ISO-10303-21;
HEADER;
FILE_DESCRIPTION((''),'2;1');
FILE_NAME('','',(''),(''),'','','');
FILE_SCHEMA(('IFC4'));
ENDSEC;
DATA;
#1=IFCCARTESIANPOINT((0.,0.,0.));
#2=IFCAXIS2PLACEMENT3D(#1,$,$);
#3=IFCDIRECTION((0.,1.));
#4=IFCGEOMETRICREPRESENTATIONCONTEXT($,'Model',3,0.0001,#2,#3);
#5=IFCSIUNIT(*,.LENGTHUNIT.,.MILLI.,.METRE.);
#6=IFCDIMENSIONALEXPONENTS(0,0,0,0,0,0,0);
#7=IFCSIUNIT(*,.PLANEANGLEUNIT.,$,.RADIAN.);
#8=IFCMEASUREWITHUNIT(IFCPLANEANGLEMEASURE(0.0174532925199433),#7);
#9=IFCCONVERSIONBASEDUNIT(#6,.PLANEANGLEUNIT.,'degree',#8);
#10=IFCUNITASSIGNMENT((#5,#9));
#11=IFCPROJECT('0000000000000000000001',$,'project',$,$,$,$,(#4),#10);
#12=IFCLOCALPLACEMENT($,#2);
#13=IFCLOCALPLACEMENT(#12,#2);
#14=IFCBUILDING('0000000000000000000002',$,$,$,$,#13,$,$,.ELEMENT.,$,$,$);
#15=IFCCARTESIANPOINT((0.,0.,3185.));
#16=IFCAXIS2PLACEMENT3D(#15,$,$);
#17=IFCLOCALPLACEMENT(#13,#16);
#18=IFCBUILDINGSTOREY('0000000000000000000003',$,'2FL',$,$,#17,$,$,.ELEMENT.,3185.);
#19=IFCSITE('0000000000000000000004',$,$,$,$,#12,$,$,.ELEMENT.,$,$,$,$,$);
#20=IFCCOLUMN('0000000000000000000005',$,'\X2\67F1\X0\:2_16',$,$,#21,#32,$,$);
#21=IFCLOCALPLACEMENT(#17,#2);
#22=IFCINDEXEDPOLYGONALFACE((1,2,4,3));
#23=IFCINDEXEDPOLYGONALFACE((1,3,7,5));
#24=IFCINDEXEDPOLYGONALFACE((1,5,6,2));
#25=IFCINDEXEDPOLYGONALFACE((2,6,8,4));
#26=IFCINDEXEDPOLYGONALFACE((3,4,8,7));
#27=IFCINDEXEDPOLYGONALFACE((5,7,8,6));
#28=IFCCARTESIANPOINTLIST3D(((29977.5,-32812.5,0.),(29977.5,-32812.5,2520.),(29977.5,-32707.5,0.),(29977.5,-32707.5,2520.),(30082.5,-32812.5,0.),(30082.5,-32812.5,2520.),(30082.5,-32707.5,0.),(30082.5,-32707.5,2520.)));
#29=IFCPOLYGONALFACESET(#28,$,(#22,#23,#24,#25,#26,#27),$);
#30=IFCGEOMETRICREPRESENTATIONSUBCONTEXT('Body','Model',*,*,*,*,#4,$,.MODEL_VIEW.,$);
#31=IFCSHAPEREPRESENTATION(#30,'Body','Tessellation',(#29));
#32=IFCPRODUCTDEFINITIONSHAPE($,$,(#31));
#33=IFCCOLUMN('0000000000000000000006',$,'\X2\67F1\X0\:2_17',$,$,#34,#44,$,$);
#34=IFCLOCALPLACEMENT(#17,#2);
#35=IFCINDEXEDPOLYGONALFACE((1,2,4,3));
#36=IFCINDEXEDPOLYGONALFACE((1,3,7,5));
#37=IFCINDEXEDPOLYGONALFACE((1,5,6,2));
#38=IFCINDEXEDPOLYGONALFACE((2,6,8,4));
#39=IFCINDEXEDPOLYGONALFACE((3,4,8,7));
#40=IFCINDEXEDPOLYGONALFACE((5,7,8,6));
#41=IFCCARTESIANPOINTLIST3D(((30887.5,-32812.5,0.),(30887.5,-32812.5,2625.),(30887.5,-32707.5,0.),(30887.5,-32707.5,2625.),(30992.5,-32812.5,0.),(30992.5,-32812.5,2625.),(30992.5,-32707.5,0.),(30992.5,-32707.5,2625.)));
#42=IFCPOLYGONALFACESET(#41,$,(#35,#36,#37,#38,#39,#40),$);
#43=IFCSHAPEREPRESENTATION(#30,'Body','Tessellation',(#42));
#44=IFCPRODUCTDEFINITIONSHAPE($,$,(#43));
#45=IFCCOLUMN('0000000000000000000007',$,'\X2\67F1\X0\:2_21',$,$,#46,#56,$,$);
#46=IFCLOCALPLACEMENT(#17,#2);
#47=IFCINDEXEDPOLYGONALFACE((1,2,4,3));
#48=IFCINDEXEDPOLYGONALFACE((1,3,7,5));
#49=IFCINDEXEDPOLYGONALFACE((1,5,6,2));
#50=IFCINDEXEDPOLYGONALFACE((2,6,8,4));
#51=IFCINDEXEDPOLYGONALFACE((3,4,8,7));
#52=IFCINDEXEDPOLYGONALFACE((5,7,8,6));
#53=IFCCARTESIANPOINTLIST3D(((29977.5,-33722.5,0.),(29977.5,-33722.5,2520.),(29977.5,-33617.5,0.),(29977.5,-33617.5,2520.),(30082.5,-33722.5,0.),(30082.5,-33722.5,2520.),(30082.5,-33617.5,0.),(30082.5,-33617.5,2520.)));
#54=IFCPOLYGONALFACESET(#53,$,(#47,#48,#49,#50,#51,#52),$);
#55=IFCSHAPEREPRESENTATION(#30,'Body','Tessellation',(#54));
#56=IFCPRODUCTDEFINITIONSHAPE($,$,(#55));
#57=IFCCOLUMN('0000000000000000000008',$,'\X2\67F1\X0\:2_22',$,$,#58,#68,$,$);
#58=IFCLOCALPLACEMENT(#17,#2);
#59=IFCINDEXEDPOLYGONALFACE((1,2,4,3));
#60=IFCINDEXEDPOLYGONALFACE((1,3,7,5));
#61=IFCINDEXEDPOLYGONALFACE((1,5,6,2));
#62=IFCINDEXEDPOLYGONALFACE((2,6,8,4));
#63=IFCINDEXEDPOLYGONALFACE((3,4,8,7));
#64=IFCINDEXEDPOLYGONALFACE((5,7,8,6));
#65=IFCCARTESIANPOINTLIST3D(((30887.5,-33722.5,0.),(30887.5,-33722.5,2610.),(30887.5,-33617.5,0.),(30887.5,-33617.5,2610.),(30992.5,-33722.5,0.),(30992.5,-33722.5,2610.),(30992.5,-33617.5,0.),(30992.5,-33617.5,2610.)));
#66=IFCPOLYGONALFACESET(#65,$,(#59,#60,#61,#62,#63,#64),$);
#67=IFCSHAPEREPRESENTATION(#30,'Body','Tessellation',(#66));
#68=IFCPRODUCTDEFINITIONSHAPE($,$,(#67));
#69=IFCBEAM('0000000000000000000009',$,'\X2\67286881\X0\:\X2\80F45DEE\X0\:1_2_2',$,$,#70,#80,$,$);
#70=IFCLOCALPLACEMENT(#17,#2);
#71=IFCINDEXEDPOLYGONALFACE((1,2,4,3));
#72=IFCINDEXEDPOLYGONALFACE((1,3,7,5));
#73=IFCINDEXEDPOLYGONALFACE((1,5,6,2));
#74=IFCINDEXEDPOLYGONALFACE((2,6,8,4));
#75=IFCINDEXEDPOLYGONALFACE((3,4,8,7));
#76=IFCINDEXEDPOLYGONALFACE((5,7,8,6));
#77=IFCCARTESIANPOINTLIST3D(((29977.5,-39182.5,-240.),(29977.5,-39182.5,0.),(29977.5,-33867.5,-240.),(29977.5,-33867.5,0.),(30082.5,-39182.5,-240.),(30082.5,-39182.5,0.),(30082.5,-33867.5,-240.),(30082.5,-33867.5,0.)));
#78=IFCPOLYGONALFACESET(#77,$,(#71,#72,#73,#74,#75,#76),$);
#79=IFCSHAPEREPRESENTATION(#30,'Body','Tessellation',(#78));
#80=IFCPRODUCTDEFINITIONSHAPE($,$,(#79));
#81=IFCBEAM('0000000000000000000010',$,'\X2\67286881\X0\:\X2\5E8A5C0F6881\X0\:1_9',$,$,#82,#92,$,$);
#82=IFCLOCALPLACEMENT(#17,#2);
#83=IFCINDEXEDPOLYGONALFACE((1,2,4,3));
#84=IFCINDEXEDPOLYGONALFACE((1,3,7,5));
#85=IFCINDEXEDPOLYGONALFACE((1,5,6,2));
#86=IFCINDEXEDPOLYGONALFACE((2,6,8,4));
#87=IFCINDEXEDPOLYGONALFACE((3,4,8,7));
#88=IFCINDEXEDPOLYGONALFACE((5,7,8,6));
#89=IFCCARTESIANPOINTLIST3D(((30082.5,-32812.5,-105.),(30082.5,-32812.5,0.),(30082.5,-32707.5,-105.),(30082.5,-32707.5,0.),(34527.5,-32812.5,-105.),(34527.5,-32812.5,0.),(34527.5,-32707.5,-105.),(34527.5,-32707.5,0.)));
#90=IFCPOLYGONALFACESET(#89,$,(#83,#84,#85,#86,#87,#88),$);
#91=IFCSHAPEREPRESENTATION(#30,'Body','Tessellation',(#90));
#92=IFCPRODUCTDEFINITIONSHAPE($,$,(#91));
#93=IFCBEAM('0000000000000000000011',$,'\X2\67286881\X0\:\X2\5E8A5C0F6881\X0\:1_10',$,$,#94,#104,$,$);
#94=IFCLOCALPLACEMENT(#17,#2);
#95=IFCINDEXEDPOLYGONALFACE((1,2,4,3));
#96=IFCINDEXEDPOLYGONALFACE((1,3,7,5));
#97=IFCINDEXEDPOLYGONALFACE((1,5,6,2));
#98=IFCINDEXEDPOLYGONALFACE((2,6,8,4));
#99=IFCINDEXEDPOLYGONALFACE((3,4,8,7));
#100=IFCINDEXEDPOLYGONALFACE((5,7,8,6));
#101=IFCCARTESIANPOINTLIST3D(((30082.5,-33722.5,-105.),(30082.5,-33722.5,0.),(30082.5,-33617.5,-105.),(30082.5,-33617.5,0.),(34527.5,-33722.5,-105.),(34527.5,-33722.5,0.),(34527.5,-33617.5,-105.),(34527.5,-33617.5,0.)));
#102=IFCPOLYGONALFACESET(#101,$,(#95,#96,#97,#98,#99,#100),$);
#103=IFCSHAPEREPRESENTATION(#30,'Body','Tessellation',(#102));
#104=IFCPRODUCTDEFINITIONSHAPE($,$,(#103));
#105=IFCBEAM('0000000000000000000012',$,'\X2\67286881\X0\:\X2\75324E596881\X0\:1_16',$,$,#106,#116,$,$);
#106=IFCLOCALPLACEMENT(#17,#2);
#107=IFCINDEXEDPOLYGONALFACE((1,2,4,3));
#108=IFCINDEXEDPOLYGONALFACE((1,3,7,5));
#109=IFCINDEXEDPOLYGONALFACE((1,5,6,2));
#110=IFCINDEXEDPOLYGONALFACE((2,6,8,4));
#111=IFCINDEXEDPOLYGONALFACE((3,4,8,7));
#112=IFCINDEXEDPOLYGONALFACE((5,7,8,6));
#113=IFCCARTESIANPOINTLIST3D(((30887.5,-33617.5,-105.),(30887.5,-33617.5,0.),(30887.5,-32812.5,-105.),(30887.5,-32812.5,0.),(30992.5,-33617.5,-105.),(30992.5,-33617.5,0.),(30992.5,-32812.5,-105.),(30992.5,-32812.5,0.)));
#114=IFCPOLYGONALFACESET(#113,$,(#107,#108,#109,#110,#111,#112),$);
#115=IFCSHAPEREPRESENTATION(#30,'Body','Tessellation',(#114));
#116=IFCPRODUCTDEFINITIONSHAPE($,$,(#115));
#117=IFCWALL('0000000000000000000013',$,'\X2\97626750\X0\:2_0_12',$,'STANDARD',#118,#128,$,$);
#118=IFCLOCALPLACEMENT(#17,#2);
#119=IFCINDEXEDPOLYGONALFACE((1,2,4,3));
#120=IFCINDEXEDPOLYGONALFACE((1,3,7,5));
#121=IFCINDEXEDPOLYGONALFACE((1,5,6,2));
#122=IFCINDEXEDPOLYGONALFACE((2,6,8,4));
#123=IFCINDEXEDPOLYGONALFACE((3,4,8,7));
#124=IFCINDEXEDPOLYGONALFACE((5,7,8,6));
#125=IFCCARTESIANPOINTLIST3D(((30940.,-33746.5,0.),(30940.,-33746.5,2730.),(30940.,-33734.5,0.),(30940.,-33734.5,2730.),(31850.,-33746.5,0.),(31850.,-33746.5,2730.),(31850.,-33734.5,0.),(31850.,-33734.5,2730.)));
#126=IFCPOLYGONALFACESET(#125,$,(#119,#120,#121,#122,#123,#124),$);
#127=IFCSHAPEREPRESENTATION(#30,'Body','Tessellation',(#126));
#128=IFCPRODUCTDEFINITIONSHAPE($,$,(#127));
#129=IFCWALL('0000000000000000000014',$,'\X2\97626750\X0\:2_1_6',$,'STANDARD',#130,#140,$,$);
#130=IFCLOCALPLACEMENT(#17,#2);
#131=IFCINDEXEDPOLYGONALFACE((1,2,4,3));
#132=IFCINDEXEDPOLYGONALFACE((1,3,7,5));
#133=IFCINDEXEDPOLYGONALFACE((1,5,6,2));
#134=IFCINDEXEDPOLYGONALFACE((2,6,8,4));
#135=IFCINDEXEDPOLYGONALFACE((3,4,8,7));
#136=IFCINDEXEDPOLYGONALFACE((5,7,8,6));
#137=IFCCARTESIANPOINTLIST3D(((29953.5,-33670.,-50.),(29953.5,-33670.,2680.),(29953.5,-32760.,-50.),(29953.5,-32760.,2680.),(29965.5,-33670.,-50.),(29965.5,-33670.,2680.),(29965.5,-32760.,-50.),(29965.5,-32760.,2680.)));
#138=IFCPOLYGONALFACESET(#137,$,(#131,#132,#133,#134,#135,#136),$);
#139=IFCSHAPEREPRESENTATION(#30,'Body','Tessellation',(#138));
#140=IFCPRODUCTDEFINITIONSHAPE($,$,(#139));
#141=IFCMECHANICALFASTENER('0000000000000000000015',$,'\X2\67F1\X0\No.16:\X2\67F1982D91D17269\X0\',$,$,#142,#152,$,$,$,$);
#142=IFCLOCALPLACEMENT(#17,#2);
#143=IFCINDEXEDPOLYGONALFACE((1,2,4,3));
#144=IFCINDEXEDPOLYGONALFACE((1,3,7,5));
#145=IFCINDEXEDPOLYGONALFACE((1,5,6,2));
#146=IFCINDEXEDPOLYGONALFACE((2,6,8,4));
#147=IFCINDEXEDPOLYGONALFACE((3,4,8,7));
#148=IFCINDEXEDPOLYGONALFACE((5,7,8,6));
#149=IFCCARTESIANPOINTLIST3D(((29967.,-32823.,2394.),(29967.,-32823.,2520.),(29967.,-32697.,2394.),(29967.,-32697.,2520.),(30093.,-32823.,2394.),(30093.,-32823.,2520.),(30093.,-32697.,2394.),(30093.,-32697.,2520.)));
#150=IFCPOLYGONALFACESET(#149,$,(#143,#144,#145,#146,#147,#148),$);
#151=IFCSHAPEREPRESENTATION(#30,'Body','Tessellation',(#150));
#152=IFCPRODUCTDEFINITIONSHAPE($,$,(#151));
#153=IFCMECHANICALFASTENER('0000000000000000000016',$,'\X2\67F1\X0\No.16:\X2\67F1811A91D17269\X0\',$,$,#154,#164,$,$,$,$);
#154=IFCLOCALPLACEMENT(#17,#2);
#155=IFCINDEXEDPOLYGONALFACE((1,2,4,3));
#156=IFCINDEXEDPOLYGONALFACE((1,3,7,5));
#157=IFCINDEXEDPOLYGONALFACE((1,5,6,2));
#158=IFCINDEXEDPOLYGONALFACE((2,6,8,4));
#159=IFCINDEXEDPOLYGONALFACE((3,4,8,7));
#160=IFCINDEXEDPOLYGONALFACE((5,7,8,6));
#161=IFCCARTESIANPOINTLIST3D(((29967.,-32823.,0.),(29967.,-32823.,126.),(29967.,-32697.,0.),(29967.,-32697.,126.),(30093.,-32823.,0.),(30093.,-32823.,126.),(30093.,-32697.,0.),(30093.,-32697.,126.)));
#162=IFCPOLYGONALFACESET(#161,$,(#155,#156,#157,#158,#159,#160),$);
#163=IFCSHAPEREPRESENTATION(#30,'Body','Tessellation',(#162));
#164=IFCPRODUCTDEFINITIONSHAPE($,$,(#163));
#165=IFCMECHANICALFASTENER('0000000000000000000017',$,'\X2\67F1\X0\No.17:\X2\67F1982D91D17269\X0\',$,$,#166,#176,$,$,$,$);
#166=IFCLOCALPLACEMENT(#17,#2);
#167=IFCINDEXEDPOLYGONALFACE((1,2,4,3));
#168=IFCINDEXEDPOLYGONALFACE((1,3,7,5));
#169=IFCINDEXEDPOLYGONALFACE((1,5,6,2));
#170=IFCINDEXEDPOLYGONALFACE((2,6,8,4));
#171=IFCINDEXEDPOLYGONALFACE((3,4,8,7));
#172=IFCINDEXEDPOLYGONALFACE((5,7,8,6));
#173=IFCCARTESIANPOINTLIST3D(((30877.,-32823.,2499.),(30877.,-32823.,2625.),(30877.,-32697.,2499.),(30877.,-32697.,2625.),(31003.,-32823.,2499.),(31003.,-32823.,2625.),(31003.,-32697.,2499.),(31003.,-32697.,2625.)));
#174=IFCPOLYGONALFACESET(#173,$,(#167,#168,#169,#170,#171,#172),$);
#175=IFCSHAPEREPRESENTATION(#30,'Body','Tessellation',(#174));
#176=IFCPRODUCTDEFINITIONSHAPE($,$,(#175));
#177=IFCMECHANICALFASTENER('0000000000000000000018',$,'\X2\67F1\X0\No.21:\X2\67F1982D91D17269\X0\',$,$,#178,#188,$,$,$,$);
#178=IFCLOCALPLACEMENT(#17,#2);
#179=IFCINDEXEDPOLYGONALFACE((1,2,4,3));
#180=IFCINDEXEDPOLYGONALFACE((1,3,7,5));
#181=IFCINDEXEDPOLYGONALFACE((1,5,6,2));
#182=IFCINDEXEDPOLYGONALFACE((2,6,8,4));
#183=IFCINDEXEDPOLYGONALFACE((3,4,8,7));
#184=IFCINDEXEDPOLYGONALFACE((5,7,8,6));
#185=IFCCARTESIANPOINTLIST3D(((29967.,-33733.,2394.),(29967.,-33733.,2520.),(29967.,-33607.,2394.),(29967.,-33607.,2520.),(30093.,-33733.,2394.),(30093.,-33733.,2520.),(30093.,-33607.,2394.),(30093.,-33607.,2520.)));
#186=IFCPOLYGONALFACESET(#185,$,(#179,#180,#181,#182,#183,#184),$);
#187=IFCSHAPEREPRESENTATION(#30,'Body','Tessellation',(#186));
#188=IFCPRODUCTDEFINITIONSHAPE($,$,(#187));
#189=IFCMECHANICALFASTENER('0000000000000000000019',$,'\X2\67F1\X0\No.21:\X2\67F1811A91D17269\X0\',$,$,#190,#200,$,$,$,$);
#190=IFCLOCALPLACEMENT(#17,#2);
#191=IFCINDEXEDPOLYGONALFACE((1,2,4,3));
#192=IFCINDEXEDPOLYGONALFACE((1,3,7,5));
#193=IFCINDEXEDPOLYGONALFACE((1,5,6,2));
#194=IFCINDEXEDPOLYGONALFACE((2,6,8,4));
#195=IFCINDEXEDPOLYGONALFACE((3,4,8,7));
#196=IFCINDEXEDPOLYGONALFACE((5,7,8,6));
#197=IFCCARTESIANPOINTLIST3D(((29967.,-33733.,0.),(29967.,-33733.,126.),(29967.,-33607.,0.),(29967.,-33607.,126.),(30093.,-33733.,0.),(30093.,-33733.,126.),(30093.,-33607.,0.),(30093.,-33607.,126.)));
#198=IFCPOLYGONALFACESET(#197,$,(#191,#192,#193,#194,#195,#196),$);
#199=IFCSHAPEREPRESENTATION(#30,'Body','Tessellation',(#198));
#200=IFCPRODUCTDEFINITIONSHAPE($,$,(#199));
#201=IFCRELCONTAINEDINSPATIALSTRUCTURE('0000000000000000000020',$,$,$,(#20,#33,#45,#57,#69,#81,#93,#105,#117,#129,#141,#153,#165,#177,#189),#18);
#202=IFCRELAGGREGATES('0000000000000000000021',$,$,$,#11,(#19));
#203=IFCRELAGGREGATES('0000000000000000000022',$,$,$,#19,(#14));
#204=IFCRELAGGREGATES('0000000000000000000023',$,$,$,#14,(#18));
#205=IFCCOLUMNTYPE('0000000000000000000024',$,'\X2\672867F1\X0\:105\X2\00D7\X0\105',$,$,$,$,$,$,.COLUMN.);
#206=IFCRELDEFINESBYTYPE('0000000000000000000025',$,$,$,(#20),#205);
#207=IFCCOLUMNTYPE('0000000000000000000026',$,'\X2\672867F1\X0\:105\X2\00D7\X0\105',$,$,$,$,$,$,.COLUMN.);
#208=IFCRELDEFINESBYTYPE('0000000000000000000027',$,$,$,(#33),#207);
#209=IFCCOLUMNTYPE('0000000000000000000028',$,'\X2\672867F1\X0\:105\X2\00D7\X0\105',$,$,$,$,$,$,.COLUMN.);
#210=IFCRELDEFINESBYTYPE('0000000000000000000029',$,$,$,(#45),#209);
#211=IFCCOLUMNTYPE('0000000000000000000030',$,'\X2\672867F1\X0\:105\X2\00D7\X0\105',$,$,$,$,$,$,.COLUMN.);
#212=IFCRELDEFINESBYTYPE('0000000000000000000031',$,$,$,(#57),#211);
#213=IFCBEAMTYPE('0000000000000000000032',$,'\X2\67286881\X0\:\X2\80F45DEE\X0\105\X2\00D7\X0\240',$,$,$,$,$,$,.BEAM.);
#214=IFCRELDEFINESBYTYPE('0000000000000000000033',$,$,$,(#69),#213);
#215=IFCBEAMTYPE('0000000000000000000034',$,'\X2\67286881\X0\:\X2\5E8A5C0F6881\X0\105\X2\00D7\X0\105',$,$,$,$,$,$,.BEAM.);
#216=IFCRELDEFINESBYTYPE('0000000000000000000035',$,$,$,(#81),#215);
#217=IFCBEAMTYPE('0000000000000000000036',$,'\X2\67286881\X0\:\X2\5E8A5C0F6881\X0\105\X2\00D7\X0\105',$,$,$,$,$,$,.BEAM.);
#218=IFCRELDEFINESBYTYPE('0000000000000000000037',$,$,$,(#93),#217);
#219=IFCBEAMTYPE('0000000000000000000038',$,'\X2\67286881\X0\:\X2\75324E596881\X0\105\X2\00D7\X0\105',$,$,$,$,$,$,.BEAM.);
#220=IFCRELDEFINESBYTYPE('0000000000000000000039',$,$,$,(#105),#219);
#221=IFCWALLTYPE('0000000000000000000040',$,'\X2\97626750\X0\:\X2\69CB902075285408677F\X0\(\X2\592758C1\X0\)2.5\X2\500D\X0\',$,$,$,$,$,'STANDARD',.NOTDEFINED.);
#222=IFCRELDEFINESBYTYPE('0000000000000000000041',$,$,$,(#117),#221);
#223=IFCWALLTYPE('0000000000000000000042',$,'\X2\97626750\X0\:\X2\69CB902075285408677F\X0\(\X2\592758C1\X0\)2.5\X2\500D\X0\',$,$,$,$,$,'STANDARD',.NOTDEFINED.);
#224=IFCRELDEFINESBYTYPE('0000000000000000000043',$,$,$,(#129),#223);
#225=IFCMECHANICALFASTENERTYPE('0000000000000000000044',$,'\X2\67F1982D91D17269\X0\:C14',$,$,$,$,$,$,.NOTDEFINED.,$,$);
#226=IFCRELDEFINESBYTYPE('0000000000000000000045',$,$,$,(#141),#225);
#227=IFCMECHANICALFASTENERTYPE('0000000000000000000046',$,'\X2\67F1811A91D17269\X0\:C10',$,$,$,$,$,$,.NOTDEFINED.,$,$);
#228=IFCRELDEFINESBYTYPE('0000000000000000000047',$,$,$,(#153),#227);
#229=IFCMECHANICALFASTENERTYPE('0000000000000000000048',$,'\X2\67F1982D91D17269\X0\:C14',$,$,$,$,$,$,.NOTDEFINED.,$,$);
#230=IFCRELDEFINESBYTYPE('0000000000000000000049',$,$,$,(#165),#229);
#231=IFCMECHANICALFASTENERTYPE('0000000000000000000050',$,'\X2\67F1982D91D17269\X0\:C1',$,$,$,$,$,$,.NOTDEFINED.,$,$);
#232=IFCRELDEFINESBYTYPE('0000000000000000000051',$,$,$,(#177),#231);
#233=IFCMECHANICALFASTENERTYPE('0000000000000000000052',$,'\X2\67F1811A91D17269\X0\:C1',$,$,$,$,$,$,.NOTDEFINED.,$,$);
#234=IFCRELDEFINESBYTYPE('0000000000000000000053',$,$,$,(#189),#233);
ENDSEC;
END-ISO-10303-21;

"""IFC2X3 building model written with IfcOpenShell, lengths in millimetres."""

from ifc_helpers import new_model, entity, si_unit, converted_unit, direction, frame, origin, origin_with_axes, origin_2d, place, context, subcontext, project, spatial, polyline, rectangle, outline, extrude, type_object, element, save


model = new_model("IFC2X3")

# Units and contexts
model_context = context("Model", 3, precision=0.0001, world=origin(), true_north=direction((0.0, 1.0)))
body_context = subcontext(model_context, "Body", "Model", "MODEL_VIEW")
ifc_project = project(units=[si_unit("LENGTHUNIT", "METRE", prefix="MILLI"), converted_unit("PLANEANGLEUNIT", "degree", entity("IfcPlaneAngleMeasure", 0.0174532925199433), si_unit("PLANEANGLEUNIT", "RADIAN"), dimensions=[0, 0, 0, 0, 0, 0, 0])], contexts=[model_context])

# Site, building, storey
site_placement = place(None, origin())
site = spatial("IfcSite", under=ifc_project, at=site_placement, CompositionType="ELEMENT")
building_placement = place(site_placement, origin())
building = spatial("IfcBuilding", under=site, at=building_placement, CompositionType="ELEMENT")
storey_placement = place(building_placement, frame((0.0, 0.0, 3185.0)))
storey = spatial("IfcBuildingStorey", under=building, at=storey_placement, Name="2FL", CompositionType="ELEMENT", Elevation=3185.0)

# Columns
column_type_1 = type_object("IfcColumnType", Name="木柱:105×105", PredefinedType="COLUMN")
column_1_placement = place(storey_placement, frame((30030.0, -32760.0, 0.0)))
element("IfcColumn", 1, at=column_1_placement, inside=storey, type_object=column_type_1, Name="柱:2_16", context=body_context, shape_type="SweptSolid", body=[
    extrude(rectangle(XDim=105.0, YDim=105.0, at=origin_2d()), origin_with_axes(), (0.0, 0.0, 1.0), 2520.0),
])
column_type_2 = type_object("IfcColumnType", Name="木柱:105×105", PredefinedType="COLUMN")
column_2_placement = place(storey_placement, frame((30940.0, -32760.0, 0.0)))
element("IfcColumn", 2, at=column_2_placement, inside=storey, type_object=column_type_2, Name="柱:2_17", context=body_context, shape_type="SweptSolid", body=[
    extrude(rectangle(XDim=105.0, YDim=105.0, at=origin_2d()), origin_with_axes(), (0.0, 0.0, 1.0), 2625.0),
])
column_type_3 = type_object("IfcColumnType", Name="木柱:105×105", PredefinedType="COLUMN")
column_3_placement = place(storey_placement, frame((30030.0, -33670.0, 0.0)))
element("IfcColumn", 3, at=column_3_placement, inside=storey, type_object=column_type_3, Name="柱:2_21", context=body_context, shape_type="SweptSolid", body=[
    extrude(rectangle(XDim=105.0, YDim=105.0, at=origin_2d()), origin_with_axes(), (0.0, 0.0, 1.0), 2520.0),
])
column_type_4 = type_object("IfcColumnType", Name="木柱:105×105", PredefinedType="COLUMN")
column_4_placement = place(storey_placement, frame((30940.0, -33670.0, 0.0)))
element("IfcColumn", 4, at=column_4_placement, inside=storey, type_object=column_type_4, Name="柱:2_22", context=body_context, shape_type="SweptSolid", body=[
    extrude(rectangle(XDim=105.0, YDim=105.0, at=origin_2d()), origin_with_axes(), (0.0, 0.0, 1.0), 2610.0),
])

# Beams
beam_type_1 = type_object("IfcBeamType", Name="木梁:胴差105×240", PredefinedType="BEAM")
beam_1_placement = place(storey_placement, frame((30030.0, -33867.5, -120.0), z_axis=(0.0, -1.0, 0.0), x_axis=(1.0, 0.0, 0.0)))
element("IfcBeam", 5, at=beam_1_placement, inside=storey, type_object=beam_type_1, Name="木梁:胴差:1_2_2", context=body_context, shape_type="SweptSolid", body=[
    extrude(rectangle(XDim=105.0, YDim=240.0, at=origin_2d()), origin_with_axes(), (0.0, 0.0, 1.0), 5315.0),
])
beam_type_2 = type_object("IfcBeamType", Name="木梁:床小梁105×105", PredefinedType="BEAM")
beam_2_placement = place(storey_placement, frame((30082.5, -32760.0, -52.5), z_axis=(1.0, 0.0, 0.0), x_axis=(0.0, 1.0, 0.0)))
element("IfcBeam", 6, at=beam_2_placement, inside=storey, type_object=beam_type_2, Name="木梁:床小梁:1_9", context=body_context, shape_type="SweptSolid", body=[
    extrude(rectangle(XDim=105.0, YDim=105.0, at=origin_2d()), origin_with_axes(), (0.0, 0.0, 1.0), 4445.0),
])
beam_type_3 = type_object("IfcBeamType", Name="木梁:床小梁105×105", PredefinedType="BEAM")
beam_3_placement = place(storey_placement, frame((30082.5, -33670.0, -52.5), z_axis=(1.0, 0.0, 0.0), x_axis=(0.0, 1.0, 0.0)))
element("IfcBeam", 7, at=beam_3_placement, inside=storey, type_object=beam_type_3, Name="木梁:床小梁:1_10", context=body_context, shape_type="SweptSolid", body=[
    extrude(rectangle(XDim=105.0, YDim=105.0, at=origin_2d()), origin_with_axes(), (0.0, 0.0, 1.0), 4445.0),
])
beam_type_4 = type_object("IfcBeamType", Name="木梁:甲乙梁105×105", PredefinedType="BEAM")
beam_4_placement = place(storey_placement, frame((30940.0, -32812.5, -52.5), z_axis=(0.0, -1.0, 0.0), x_axis=(1.0, 0.0, 0.0)))
element("IfcBeam", 8, at=beam_4_placement, inside=storey, type_object=beam_type_4, Name="木梁:甲乙梁:1_16", context=body_context, shape_type="SweptSolid", body=[
    extrude(rectangle(XDim=105.0, YDim=105.0, at=origin_2d()), origin_with_axes(), (0.0, 0.0, 1.0), 805.0),
])

# Walls
wall_type_1 = type_object("IfcWallType", Name="面材:構造用合板(大壁)2.5倍", ElementType="STANDARD", PredefinedType="NOTDEFINED")
wall_1_placement = place(storey_placement, frame((31395.0, -33734.5, 0.0), z_axis=(0.0, -1.0, 0.0), x_axis=(1.0, 0.0, 0.0)))
element("IfcWall", 9, at=wall_1_placement, inside=storey, type_object=wall_type_1, Name="面材:2_0_12", ObjectType="STANDARD", context=body_context, shape_type="SweptSolid", body=[
    extrude(outline(polyline([(455.0, 0.0, 0.0), (-455.0, 0.0, 0.0), (-455.0, 2730.0, 0.0), (455.0, 2730.0, 0.0), (455.0, 0.0, 0.0)])), origin_with_axes(), (0.0, 0.0, 1.0), 12.0),
])
wall_type_2 = type_object("IfcWallType", Name="面材:構造用合板(大壁)2.5倍", ElementType="STANDARD", PredefinedType="NOTDEFINED")
wall_2_placement = place(storey_placement, frame((29965.5, -33215.0, -50.0), z_axis=(-1.0, 0.0, 0.0), x_axis=(0.0, -1.0, 0.0)))
element("IfcWall", 10, at=wall_2_placement, inside=storey, type_object=wall_type_2, Name="面材:2_1_6", ObjectType="STANDARD", context=body_context, shape_type="SweptSolid", body=[
    extrude(outline(polyline([(455.0, 0.0, 0.0), (-455.0, 0.0, 0.0), (-455.0, 2730.0, 0.0), (455.0, 2730.0, 0.0), (455.0, 0.0, 0.0)])), origin_with_axes(), (0.0, 0.0, 1.0), 12.0),
])

# Mechanical fasteners
mechanical_fastener_type_1 = type_object("IfcMechanicalFastenerType", Name="柱頭金物:C14")
mechanical_fastener_1_placement = place(storey_placement, frame((30030.0, -32760.0, 2394.0)))
element("IfcMechanicalFastener", 11, at=mechanical_fastener_1_placement, inside=storey, type_object=mechanical_fastener_type_1, Name="柱No.16:柱頭金物", context=body_context, shape_type="SweptSolid", body=[
    extrude(rectangle(XDim=126.0, YDim=126.0, at=origin_2d()), origin_with_axes(), (0.0, 0.0, 1.0), 126.0),
])
mechanical_fastener_type_2 = type_object("IfcMechanicalFastenerType", Name="柱脚金物:C10")
mechanical_fastener_2_placement = place(storey_placement, frame((30030.0, -32760.0, 0.0)))
element("IfcMechanicalFastener", 12, at=mechanical_fastener_2_placement, inside=storey, type_object=mechanical_fastener_type_2, Name="柱No.16:柱脚金物", context=body_context, shape_type="SweptSolid", body=[
    extrude(rectangle(XDim=126.0, YDim=126.0, at=origin_2d()), origin_with_axes(), (0.0, 0.0, 1.0), 126.0),
])
mechanical_fastener_type_3 = type_object("IfcMechanicalFastenerType", Name="柱頭金物:C14")
mechanical_fastener_3_placement = place(storey_placement, frame((30940.0, -32760.0, 2499.0)))
element("IfcMechanicalFastener", 13, at=mechanical_fastener_3_placement, inside=storey, type_object=mechanical_fastener_type_3, Name="柱No.17:柱頭金物", context=body_context, shape_type="SweptSolid", body=[
    extrude(rectangle(XDim=126.0, YDim=126.0, at=origin_2d()), origin_with_axes(), (0.0, 0.0, 1.0), 126.0),
])
mechanical_fastener_type_4 = type_object("IfcMechanicalFastenerType", Name="柱頭金物:C1")
mechanical_fastener_4_placement = place(storey_placement, frame((30030.0, -33670.0, 2394.0)))
element("IfcMechanicalFastener", 14, at=mechanical_fastener_4_placement, inside=storey, type_object=mechanical_fastener_type_4, Name="柱No.21:柱頭金物", context=body_context, shape_type="SweptSolid", body=[
    extrude(rectangle(XDim=126.0, YDim=126.0, at=origin_2d()), origin_with_axes(), (0.0, 0.0, 1.0), 126.0),
])
mechanical_fastener_type_5 = type_object("IfcMechanicalFastenerType", Name="柱脚金物:C1")
mechanical_fastener_5_placement = place(storey_placement, frame((30030.0, -33670.0, 0.0)))
element("IfcMechanicalFastener", 15, at=mechanical_fastener_5_placement, inside=storey, type_object=mechanical_fastener_type_5, Name="柱No.21:柱脚金物", context=body_context, shape_type="SweptSolid", body=[
    extrude(rectangle(XDim=126.0, YDim=126.0, at=origin_2d()), origin_with_axes(), (0.0, 0.0, 1.0), 126.0),
])

save(model, "model.ifc")
